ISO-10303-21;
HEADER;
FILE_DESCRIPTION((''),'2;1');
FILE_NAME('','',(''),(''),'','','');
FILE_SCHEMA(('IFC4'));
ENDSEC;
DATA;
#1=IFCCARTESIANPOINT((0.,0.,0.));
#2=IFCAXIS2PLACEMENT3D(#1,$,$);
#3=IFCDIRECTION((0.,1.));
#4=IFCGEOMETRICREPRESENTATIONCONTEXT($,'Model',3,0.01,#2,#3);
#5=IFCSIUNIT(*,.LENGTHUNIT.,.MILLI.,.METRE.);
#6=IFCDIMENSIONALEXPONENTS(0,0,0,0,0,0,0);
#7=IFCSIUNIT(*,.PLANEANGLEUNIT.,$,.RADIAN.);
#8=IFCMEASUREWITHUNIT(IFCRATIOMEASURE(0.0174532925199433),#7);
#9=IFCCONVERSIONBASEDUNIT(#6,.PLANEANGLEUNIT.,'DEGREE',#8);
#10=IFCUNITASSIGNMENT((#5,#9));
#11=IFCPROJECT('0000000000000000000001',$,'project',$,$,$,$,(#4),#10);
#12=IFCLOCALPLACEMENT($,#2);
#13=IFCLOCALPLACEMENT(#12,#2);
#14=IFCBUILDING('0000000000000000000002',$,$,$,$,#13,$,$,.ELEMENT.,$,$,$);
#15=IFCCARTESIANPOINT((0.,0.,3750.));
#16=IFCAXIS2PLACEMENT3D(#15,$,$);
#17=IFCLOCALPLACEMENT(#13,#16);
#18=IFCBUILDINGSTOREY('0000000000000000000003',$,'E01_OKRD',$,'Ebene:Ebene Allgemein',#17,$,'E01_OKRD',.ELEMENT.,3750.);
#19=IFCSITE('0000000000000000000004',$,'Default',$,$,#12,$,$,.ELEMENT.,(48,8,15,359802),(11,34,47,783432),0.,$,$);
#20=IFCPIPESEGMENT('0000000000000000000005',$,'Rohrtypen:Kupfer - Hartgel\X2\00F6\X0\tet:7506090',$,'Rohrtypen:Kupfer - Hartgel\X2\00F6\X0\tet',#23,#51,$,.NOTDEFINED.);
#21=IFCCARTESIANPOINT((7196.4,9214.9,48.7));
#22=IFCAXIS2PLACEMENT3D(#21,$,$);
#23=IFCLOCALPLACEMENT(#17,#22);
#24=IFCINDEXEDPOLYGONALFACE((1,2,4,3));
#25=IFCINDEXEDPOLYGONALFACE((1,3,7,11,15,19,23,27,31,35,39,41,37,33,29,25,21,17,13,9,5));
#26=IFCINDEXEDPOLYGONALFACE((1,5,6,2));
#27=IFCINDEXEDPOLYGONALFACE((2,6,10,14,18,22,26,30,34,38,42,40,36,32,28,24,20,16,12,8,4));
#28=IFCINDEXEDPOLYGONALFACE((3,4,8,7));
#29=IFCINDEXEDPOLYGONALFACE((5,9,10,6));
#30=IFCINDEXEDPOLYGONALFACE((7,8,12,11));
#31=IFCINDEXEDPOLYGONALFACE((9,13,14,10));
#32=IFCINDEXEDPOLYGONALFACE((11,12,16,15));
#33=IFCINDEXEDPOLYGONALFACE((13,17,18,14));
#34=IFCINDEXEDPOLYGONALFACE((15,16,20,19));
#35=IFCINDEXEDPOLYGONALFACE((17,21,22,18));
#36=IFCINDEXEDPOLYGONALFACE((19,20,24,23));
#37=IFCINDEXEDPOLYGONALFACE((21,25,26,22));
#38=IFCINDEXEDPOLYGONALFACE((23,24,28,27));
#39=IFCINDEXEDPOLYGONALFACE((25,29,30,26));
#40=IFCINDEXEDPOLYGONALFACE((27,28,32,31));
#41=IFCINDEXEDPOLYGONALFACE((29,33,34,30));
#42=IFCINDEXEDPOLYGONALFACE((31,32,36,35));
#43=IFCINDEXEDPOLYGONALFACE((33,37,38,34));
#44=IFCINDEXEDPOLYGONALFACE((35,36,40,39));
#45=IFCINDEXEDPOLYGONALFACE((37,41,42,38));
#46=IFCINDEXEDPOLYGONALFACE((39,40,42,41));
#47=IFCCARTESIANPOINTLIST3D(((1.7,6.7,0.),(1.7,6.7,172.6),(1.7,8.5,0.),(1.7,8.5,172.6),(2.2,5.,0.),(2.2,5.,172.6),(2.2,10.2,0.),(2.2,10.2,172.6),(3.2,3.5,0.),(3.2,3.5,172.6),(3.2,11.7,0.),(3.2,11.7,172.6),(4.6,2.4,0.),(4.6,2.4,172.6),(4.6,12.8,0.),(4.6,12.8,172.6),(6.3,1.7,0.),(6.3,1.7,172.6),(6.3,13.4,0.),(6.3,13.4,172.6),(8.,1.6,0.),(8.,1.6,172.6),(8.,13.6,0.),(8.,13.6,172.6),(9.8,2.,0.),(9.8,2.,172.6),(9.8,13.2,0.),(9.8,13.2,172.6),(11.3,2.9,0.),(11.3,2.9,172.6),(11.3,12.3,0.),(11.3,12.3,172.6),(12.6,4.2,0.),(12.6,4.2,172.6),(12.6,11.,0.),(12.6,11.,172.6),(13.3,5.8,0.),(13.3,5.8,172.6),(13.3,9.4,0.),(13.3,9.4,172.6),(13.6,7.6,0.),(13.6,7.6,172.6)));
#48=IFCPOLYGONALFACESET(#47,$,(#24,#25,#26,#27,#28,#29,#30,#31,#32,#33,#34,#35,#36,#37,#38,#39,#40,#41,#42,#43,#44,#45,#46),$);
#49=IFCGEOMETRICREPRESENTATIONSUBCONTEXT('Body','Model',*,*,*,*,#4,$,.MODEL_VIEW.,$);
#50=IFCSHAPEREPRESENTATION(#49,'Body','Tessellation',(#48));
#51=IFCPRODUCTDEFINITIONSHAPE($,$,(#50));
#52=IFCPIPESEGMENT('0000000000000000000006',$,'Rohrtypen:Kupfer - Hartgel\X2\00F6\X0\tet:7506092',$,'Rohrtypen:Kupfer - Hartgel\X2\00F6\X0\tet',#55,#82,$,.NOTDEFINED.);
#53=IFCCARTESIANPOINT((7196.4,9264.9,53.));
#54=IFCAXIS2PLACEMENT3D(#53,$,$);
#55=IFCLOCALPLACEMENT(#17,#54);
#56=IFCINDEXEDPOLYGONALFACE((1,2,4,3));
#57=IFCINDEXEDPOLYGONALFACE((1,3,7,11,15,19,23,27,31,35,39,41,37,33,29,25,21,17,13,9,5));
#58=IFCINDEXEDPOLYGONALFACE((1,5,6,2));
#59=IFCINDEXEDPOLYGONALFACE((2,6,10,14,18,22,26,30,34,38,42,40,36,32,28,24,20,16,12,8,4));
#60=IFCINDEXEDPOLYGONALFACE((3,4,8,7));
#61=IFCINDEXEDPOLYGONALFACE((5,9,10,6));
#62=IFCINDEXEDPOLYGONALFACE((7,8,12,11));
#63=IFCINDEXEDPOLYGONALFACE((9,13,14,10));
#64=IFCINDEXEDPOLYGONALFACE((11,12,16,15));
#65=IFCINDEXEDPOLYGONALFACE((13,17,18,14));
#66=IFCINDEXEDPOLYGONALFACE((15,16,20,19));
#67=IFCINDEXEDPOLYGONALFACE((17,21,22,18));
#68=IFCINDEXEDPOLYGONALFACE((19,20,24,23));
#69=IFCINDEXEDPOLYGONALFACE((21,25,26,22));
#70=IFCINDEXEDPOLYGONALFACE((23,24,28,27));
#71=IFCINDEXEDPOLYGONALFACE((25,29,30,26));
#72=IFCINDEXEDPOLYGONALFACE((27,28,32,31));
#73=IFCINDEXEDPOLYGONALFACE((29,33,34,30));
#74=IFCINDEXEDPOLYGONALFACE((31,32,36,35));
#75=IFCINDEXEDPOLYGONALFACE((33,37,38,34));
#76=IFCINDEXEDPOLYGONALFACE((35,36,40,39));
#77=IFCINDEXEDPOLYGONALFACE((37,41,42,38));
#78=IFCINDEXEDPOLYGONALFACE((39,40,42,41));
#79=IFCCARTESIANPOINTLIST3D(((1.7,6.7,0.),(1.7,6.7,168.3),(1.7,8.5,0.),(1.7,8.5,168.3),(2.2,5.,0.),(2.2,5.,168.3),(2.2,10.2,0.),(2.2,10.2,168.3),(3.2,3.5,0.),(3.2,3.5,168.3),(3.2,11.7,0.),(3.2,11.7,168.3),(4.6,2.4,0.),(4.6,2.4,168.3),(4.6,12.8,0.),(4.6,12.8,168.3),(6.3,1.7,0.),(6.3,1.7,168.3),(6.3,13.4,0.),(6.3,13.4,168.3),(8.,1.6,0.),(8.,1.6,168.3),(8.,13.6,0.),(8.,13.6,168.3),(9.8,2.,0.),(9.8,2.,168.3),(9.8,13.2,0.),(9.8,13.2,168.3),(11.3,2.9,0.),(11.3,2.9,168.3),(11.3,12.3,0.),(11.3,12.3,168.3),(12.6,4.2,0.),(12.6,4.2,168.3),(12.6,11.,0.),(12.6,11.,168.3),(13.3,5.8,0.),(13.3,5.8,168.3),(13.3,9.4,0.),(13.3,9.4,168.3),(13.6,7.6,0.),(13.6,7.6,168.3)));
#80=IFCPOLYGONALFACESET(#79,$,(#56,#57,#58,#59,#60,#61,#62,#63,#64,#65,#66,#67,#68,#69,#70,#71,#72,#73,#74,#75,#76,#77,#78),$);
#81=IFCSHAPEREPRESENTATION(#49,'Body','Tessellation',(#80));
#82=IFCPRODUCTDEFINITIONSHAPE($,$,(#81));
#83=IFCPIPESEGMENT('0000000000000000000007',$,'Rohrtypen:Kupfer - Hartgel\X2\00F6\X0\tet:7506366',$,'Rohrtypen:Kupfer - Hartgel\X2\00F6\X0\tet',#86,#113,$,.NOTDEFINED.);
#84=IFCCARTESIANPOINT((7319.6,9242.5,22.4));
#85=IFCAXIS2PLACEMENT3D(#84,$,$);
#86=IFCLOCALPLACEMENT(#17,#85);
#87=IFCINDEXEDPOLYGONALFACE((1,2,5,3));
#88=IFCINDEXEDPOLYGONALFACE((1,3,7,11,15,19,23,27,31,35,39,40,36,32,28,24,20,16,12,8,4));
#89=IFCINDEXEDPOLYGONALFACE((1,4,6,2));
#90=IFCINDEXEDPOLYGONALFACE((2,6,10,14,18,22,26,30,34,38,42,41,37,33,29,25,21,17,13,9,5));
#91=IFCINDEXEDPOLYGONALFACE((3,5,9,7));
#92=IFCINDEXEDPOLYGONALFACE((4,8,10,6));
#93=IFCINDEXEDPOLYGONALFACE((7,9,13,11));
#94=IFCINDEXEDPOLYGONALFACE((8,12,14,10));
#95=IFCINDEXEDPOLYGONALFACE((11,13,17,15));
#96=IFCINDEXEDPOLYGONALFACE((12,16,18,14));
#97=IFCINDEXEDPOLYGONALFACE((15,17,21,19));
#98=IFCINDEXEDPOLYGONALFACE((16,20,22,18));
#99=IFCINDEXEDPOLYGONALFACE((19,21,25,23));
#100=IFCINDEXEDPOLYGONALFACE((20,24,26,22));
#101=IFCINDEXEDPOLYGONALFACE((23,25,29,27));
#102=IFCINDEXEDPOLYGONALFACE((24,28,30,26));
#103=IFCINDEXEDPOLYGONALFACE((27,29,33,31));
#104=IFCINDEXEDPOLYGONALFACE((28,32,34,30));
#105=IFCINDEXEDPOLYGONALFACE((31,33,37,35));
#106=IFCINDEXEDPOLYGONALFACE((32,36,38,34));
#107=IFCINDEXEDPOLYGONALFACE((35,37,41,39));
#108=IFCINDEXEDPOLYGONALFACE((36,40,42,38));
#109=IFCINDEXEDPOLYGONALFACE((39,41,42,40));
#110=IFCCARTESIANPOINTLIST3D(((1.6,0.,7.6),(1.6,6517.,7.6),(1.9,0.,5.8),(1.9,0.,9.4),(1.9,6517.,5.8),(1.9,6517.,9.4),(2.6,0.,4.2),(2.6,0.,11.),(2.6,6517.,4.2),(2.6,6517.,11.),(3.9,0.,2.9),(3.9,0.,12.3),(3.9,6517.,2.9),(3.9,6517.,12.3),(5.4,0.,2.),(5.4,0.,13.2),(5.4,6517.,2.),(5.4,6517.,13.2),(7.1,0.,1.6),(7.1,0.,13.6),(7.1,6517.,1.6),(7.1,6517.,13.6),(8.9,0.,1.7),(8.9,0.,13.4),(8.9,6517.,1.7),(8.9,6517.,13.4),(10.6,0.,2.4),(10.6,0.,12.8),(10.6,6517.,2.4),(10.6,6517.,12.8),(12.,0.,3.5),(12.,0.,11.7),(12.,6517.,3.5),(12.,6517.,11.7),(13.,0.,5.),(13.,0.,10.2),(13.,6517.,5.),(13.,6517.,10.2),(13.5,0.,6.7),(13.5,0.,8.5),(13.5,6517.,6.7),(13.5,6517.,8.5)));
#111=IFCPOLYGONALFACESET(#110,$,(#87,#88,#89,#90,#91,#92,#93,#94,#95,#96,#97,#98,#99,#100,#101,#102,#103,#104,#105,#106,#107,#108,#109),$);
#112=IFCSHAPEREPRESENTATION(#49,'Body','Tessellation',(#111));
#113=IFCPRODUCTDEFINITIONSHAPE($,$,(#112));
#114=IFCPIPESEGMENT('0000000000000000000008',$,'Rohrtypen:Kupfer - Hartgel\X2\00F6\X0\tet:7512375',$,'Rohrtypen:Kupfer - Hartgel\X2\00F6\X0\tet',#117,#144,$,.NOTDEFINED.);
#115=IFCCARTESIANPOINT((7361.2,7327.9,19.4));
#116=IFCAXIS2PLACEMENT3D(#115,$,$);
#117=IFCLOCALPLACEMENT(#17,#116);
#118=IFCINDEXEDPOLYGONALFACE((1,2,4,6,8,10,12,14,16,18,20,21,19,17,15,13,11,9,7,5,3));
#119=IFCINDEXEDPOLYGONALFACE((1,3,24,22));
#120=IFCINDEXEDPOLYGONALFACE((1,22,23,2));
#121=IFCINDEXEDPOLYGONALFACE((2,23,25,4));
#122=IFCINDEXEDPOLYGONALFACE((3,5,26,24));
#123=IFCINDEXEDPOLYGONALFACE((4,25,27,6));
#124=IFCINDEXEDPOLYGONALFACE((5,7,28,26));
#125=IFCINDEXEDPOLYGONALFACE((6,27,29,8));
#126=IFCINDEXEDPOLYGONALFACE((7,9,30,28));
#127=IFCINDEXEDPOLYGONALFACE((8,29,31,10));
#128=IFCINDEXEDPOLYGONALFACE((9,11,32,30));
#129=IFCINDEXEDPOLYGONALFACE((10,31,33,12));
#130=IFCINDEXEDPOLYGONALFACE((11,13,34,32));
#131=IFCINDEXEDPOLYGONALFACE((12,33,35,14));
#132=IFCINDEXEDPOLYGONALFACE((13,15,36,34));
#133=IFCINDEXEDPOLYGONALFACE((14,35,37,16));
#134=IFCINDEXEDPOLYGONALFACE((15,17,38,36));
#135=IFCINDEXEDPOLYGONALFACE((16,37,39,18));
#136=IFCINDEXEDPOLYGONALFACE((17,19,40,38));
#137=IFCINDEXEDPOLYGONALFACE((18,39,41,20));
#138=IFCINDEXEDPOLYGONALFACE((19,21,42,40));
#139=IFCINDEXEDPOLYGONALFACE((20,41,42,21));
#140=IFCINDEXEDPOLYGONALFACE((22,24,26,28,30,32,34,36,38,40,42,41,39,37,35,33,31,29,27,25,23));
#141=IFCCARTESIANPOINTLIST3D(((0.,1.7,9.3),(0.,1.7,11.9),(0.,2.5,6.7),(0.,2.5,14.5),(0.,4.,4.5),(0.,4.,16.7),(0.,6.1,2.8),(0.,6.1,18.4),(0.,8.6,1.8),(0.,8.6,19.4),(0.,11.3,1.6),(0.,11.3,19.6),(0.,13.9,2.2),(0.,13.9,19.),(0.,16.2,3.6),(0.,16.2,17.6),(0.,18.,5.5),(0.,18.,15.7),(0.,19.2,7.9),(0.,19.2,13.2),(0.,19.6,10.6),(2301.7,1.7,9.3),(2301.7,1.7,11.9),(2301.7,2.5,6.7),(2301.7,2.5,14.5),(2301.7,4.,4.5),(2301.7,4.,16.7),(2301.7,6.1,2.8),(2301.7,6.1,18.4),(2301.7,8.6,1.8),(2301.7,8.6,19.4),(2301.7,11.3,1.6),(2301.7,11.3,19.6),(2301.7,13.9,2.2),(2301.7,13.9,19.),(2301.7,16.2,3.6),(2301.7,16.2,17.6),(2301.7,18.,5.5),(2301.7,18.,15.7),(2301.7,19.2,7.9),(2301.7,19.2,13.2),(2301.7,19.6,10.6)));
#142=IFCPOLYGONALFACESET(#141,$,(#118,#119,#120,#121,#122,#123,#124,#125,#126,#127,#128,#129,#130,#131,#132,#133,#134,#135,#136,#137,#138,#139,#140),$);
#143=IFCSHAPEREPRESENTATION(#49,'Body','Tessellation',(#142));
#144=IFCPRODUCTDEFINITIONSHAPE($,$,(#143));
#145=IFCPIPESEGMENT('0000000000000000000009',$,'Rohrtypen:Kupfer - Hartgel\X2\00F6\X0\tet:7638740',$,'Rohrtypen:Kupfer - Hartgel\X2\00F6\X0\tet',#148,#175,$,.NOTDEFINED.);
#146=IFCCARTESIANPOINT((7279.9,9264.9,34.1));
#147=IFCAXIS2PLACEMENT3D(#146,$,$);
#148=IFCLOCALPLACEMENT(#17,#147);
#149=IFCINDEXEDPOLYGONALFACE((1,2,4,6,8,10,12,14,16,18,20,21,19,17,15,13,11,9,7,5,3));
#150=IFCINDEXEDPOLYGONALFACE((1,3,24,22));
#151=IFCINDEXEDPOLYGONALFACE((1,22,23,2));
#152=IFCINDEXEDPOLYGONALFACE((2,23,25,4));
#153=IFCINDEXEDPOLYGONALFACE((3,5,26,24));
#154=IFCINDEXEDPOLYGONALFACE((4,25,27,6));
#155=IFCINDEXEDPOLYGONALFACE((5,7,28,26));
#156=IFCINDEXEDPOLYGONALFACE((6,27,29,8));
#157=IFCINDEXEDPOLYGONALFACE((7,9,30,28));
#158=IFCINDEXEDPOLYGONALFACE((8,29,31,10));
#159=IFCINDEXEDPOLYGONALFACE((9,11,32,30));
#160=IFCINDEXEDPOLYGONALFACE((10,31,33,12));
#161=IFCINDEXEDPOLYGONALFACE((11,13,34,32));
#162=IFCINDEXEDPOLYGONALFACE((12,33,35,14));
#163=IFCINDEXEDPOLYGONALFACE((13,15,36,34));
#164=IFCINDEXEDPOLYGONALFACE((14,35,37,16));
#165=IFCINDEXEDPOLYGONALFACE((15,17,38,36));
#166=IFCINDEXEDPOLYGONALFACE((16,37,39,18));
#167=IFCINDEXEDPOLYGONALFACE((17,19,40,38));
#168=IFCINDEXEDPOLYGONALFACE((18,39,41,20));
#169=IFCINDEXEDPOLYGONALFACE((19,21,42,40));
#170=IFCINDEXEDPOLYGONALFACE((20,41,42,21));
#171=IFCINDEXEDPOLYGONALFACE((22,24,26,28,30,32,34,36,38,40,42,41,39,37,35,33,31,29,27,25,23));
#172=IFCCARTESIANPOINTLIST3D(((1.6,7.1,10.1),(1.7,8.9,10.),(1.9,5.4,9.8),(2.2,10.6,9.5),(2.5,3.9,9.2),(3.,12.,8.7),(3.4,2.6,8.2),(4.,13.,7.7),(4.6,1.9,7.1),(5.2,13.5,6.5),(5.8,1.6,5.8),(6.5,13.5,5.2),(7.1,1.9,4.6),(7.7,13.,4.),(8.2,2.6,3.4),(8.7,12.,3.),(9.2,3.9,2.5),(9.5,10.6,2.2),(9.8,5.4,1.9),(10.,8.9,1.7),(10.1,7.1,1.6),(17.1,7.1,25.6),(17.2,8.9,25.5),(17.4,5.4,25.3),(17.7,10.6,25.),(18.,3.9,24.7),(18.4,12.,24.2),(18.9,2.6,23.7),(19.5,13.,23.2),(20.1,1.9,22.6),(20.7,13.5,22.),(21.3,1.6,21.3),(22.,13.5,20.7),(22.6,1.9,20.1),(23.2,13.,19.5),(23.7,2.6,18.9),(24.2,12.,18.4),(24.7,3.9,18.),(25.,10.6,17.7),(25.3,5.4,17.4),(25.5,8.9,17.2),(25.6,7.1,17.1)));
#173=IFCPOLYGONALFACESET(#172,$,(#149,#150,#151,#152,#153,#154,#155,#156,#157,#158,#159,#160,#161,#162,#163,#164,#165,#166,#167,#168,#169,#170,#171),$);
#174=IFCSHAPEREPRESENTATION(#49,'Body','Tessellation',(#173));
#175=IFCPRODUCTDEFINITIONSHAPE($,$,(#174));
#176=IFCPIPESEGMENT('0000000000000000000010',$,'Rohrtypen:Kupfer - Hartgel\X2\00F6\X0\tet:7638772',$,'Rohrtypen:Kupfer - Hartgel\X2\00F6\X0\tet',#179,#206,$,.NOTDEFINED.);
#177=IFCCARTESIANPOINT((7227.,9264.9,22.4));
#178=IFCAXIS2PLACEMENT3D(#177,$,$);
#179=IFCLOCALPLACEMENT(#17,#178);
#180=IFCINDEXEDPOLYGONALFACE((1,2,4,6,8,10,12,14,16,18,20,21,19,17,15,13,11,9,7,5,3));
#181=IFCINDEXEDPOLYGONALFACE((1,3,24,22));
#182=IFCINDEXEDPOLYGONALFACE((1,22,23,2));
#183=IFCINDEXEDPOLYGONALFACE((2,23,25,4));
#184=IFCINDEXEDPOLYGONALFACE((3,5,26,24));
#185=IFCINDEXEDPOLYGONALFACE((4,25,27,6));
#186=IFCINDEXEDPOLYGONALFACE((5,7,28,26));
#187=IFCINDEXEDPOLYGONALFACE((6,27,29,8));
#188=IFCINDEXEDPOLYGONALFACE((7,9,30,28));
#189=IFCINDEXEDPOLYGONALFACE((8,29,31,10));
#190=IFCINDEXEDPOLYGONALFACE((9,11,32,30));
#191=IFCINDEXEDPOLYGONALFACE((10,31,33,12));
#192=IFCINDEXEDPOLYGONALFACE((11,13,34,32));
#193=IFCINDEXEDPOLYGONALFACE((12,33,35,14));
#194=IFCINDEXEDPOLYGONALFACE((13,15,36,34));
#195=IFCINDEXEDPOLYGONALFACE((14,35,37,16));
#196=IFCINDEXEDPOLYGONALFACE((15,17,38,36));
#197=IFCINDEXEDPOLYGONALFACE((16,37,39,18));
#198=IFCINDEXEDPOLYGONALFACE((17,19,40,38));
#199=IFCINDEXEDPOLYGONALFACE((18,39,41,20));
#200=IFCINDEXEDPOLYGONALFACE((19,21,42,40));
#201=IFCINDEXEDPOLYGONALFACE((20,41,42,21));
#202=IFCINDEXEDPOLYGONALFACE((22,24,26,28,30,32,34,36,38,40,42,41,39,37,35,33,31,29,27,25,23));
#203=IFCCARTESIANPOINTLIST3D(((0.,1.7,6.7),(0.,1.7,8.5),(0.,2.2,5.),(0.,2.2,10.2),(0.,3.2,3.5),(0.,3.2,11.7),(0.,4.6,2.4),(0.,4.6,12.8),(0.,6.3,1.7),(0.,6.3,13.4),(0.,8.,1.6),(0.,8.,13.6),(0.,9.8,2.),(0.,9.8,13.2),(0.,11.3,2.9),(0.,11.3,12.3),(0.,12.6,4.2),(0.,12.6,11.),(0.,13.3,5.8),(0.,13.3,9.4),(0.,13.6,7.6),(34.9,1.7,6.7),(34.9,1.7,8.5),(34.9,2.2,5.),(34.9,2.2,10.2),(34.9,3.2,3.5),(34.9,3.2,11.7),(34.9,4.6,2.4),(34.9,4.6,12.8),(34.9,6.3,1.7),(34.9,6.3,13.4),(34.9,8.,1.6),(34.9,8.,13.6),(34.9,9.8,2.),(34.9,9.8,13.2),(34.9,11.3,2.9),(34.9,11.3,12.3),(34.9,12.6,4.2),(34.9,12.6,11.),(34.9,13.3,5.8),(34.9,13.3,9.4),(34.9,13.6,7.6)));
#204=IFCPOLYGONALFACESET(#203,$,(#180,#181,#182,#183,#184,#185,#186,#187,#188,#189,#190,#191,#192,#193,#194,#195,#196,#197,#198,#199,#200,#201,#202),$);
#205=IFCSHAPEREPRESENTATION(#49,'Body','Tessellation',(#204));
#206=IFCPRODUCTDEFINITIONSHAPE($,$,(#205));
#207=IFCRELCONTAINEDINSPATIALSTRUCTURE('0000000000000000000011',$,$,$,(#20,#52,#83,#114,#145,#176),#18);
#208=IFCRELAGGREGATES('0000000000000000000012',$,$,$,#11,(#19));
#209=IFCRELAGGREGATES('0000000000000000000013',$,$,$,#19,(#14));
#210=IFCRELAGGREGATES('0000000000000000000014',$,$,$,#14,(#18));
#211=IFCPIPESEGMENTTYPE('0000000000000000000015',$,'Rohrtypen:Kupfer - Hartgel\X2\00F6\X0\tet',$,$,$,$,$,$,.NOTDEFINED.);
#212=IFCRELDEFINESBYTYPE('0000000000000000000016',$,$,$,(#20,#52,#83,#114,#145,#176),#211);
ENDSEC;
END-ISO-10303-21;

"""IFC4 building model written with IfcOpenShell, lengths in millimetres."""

from ifc_helpers import new_model, entity, si_unit, converted_unit, direction, frame, frame_2d, origin, origin_2d_with_axis, place, context, subcontext, project, spatial, circle, extrude, type_object, element, save


model = new_model("IFC4")

# Units and contexts
model_context = context("Model", 3, precision=0.01, world=origin(), true_north=direction((0.0, 1.0)))
body_context = subcontext(model_context, "Body", "Model", "MODEL_VIEW")
ifc_project = project(units=[si_unit("LENGTHUNIT", "METRE", prefix="MILLI"), converted_unit("PLANEANGLEUNIT", "DEGREE", entity("IfcRatioMeasure", 0.0174532925199433), si_unit("PLANEANGLEUNIT", "RADIAN"), dimensions=[0, 0, 0, 0, 0, 0, 0])], contexts=[model_context])

# Site, building, storey
site_placement = place(None, origin())
site = spatial("IfcSite", under=ifc_project, at=site_placement, Name="Default", CompositionType="ELEMENT", RefLatitude=(48, 8, 15, 359802), RefLongitude=(11, 34, 47, 783432), RefElevation=0.0)
building_placement = place(site_placement, origin())
building = spatial("IfcBuilding", under=site, at=building_placement, CompositionType="ELEMENT")
storey_placement = place(building_placement, frame((0.0, 0.0, 3750.0)))
storey = spatial("IfcBuildingStorey", under=building, at=storey_placement, Name="E01_OKRD", ObjectType="Ebene:Ebene Allgemein", LongName="E01_OKRD", CompositionType="ELEMENT", Elevation=3750.0)

# Pipe segments
pipe_segment_type = type_object("IfcPipeSegmentType", Name="Rohrtypen:Kupfer - Hartgelötet", PredefinedType="NOTDEFINED")
pipe_segment_1_placement = place(storey_placement, frame((7196.4, 9214.9, 48.7)))
element("IfcPipeSegment", 1, at=pipe_segment_1_placement, inside=storey, type_object=pipe_segment_type, Name="Rohrtypen:Kupfer - Hartgelötet:7506090", ObjectType="Rohrtypen:Kupfer - Hartgelötet", PredefinedType="NOTDEFINED", context=body_context, shape_type="SweptSolid", body=[
    extrude(circle(Radius=6.0, at=frame_2d((0.0, 0.0), x_axis=(1.0, 0.0))), frame((7.6, 7.6, 0.0)), (0.0, 0.0, 1.0), 172.6),
])
pipe_segment_2_placement = place(storey_placement, frame((7196.4, 9264.9, 53.0)))
element("IfcPipeSegment", 2, at=pipe_segment_2_placement, inside=storey, type_object=pipe_segment_type, Name="Rohrtypen:Kupfer - Hartgelötet:7506092", ObjectType="Rohrtypen:Kupfer - Hartgelötet", PredefinedType="NOTDEFINED", context=body_context, shape_type="SweptSolid", body=[
    extrude(circle(Radius=6.0, at=frame_2d((0.0, 0.0), x_axis=(1.0, 0.0))), frame((7.6, 7.6, 0.0)), (0.0, 0.0, 1.0), 168.3),
])
pipe_segment_3_placement = place(storey_placement, frame((7319.6, 9242.5, 22.4)))
element("IfcPipeSegment", 3, at=pipe_segment_3_placement, inside=storey, type_object=pipe_segment_type, Name="Rohrtypen:Kupfer - Hartgelötet:7506366", ObjectType="Rohrtypen:Kupfer - Hartgelötet", PredefinedType="NOTDEFINED", context=body_context, shape_type="SweptSolid", body=[
    extrude(circle(Radius=6.0, at=origin_2d_with_axis()), frame((7.6, 0.0, 7.6), z_axis=(0.0, 1.0, 0.0), x_axis=(-1.0, 0.0, 0.0)), (0.0, 0.0, 1.0), 6517.0),
])
pipe_segment_4_placement = place(storey_placement, frame((7361.2, 7327.9, 19.4)))
element("IfcPipeSegment", 4, at=pipe_segment_4_placement, inside=storey, type_object=pipe_segment_type, Name="Rohrtypen:Kupfer - Hartgelötet:7512375", ObjectType="Rohrtypen:Kupfer - Hartgelötet", PredefinedType="NOTDEFINED", context=body_context, shape_type="SweptSolid", body=[
    extrude(circle(Radius=9.0, at=frame_2d((0.0, 0.0), x_axis=(1.0, 0.0))), frame((0.0, 10.6, 10.6), z_axis=(1.0, 0.0, 0.0), x_axis=(0.0, 1.0, 0.0)), (0.0, 0.0, 1.0), 2301.7),
])
pipe_segment_5_placement = place(storey_placement, frame((7279.9, 9264.9, 34.1)))
element("IfcPipeSegment", 5, at=pipe_segment_5_placement, inside=storey, type_object=pipe_segment_type, Name="Rohrtypen:Kupfer - Hartgelötet:7638740", ObjectType="Rohrtypen:Kupfer - Hartgelötet", PredefinedType="NOTDEFINED", context=body_context, shape_type="SweptSolid", body=[
    extrude(circle(Radius=6.0, at=origin_2d_with_axis()), frame((5.8, 7.6, 5.8), z_axis=(0.707107, 0.0, 0.707107), x_axis=(0.0, -1.0, 0.0)), (0.0, 0.0, 1.0), 21.9),
])
pipe_segment_6_placement = place(storey_placement, frame((7227.0, 9264.9, 22.4)))
element("IfcPipeSegment", 6, at=pipe_segment_6_placement, inside=storey, type_object=pipe_segment_type, Name="Rohrtypen:Kupfer - Hartgelötet:7638772", ObjectType="Rohrtypen:Kupfer - Hartgelötet", PredefinedType="NOTDEFINED", context=body_context, shape_type="SweptSolid", body=[
    extrude(circle(Radius=6.0, at=frame_2d((0.0, 0.0), x_axis=(1.0, 0.0))), frame((0.0, 7.6, 7.6), z_axis=(1.0, 0.0, 0.0), x_axis=(0.0, 1.0, 0.0)), (0.0, 0.0, 1.0), 34.9),
])

save(model, "model.ifc")
